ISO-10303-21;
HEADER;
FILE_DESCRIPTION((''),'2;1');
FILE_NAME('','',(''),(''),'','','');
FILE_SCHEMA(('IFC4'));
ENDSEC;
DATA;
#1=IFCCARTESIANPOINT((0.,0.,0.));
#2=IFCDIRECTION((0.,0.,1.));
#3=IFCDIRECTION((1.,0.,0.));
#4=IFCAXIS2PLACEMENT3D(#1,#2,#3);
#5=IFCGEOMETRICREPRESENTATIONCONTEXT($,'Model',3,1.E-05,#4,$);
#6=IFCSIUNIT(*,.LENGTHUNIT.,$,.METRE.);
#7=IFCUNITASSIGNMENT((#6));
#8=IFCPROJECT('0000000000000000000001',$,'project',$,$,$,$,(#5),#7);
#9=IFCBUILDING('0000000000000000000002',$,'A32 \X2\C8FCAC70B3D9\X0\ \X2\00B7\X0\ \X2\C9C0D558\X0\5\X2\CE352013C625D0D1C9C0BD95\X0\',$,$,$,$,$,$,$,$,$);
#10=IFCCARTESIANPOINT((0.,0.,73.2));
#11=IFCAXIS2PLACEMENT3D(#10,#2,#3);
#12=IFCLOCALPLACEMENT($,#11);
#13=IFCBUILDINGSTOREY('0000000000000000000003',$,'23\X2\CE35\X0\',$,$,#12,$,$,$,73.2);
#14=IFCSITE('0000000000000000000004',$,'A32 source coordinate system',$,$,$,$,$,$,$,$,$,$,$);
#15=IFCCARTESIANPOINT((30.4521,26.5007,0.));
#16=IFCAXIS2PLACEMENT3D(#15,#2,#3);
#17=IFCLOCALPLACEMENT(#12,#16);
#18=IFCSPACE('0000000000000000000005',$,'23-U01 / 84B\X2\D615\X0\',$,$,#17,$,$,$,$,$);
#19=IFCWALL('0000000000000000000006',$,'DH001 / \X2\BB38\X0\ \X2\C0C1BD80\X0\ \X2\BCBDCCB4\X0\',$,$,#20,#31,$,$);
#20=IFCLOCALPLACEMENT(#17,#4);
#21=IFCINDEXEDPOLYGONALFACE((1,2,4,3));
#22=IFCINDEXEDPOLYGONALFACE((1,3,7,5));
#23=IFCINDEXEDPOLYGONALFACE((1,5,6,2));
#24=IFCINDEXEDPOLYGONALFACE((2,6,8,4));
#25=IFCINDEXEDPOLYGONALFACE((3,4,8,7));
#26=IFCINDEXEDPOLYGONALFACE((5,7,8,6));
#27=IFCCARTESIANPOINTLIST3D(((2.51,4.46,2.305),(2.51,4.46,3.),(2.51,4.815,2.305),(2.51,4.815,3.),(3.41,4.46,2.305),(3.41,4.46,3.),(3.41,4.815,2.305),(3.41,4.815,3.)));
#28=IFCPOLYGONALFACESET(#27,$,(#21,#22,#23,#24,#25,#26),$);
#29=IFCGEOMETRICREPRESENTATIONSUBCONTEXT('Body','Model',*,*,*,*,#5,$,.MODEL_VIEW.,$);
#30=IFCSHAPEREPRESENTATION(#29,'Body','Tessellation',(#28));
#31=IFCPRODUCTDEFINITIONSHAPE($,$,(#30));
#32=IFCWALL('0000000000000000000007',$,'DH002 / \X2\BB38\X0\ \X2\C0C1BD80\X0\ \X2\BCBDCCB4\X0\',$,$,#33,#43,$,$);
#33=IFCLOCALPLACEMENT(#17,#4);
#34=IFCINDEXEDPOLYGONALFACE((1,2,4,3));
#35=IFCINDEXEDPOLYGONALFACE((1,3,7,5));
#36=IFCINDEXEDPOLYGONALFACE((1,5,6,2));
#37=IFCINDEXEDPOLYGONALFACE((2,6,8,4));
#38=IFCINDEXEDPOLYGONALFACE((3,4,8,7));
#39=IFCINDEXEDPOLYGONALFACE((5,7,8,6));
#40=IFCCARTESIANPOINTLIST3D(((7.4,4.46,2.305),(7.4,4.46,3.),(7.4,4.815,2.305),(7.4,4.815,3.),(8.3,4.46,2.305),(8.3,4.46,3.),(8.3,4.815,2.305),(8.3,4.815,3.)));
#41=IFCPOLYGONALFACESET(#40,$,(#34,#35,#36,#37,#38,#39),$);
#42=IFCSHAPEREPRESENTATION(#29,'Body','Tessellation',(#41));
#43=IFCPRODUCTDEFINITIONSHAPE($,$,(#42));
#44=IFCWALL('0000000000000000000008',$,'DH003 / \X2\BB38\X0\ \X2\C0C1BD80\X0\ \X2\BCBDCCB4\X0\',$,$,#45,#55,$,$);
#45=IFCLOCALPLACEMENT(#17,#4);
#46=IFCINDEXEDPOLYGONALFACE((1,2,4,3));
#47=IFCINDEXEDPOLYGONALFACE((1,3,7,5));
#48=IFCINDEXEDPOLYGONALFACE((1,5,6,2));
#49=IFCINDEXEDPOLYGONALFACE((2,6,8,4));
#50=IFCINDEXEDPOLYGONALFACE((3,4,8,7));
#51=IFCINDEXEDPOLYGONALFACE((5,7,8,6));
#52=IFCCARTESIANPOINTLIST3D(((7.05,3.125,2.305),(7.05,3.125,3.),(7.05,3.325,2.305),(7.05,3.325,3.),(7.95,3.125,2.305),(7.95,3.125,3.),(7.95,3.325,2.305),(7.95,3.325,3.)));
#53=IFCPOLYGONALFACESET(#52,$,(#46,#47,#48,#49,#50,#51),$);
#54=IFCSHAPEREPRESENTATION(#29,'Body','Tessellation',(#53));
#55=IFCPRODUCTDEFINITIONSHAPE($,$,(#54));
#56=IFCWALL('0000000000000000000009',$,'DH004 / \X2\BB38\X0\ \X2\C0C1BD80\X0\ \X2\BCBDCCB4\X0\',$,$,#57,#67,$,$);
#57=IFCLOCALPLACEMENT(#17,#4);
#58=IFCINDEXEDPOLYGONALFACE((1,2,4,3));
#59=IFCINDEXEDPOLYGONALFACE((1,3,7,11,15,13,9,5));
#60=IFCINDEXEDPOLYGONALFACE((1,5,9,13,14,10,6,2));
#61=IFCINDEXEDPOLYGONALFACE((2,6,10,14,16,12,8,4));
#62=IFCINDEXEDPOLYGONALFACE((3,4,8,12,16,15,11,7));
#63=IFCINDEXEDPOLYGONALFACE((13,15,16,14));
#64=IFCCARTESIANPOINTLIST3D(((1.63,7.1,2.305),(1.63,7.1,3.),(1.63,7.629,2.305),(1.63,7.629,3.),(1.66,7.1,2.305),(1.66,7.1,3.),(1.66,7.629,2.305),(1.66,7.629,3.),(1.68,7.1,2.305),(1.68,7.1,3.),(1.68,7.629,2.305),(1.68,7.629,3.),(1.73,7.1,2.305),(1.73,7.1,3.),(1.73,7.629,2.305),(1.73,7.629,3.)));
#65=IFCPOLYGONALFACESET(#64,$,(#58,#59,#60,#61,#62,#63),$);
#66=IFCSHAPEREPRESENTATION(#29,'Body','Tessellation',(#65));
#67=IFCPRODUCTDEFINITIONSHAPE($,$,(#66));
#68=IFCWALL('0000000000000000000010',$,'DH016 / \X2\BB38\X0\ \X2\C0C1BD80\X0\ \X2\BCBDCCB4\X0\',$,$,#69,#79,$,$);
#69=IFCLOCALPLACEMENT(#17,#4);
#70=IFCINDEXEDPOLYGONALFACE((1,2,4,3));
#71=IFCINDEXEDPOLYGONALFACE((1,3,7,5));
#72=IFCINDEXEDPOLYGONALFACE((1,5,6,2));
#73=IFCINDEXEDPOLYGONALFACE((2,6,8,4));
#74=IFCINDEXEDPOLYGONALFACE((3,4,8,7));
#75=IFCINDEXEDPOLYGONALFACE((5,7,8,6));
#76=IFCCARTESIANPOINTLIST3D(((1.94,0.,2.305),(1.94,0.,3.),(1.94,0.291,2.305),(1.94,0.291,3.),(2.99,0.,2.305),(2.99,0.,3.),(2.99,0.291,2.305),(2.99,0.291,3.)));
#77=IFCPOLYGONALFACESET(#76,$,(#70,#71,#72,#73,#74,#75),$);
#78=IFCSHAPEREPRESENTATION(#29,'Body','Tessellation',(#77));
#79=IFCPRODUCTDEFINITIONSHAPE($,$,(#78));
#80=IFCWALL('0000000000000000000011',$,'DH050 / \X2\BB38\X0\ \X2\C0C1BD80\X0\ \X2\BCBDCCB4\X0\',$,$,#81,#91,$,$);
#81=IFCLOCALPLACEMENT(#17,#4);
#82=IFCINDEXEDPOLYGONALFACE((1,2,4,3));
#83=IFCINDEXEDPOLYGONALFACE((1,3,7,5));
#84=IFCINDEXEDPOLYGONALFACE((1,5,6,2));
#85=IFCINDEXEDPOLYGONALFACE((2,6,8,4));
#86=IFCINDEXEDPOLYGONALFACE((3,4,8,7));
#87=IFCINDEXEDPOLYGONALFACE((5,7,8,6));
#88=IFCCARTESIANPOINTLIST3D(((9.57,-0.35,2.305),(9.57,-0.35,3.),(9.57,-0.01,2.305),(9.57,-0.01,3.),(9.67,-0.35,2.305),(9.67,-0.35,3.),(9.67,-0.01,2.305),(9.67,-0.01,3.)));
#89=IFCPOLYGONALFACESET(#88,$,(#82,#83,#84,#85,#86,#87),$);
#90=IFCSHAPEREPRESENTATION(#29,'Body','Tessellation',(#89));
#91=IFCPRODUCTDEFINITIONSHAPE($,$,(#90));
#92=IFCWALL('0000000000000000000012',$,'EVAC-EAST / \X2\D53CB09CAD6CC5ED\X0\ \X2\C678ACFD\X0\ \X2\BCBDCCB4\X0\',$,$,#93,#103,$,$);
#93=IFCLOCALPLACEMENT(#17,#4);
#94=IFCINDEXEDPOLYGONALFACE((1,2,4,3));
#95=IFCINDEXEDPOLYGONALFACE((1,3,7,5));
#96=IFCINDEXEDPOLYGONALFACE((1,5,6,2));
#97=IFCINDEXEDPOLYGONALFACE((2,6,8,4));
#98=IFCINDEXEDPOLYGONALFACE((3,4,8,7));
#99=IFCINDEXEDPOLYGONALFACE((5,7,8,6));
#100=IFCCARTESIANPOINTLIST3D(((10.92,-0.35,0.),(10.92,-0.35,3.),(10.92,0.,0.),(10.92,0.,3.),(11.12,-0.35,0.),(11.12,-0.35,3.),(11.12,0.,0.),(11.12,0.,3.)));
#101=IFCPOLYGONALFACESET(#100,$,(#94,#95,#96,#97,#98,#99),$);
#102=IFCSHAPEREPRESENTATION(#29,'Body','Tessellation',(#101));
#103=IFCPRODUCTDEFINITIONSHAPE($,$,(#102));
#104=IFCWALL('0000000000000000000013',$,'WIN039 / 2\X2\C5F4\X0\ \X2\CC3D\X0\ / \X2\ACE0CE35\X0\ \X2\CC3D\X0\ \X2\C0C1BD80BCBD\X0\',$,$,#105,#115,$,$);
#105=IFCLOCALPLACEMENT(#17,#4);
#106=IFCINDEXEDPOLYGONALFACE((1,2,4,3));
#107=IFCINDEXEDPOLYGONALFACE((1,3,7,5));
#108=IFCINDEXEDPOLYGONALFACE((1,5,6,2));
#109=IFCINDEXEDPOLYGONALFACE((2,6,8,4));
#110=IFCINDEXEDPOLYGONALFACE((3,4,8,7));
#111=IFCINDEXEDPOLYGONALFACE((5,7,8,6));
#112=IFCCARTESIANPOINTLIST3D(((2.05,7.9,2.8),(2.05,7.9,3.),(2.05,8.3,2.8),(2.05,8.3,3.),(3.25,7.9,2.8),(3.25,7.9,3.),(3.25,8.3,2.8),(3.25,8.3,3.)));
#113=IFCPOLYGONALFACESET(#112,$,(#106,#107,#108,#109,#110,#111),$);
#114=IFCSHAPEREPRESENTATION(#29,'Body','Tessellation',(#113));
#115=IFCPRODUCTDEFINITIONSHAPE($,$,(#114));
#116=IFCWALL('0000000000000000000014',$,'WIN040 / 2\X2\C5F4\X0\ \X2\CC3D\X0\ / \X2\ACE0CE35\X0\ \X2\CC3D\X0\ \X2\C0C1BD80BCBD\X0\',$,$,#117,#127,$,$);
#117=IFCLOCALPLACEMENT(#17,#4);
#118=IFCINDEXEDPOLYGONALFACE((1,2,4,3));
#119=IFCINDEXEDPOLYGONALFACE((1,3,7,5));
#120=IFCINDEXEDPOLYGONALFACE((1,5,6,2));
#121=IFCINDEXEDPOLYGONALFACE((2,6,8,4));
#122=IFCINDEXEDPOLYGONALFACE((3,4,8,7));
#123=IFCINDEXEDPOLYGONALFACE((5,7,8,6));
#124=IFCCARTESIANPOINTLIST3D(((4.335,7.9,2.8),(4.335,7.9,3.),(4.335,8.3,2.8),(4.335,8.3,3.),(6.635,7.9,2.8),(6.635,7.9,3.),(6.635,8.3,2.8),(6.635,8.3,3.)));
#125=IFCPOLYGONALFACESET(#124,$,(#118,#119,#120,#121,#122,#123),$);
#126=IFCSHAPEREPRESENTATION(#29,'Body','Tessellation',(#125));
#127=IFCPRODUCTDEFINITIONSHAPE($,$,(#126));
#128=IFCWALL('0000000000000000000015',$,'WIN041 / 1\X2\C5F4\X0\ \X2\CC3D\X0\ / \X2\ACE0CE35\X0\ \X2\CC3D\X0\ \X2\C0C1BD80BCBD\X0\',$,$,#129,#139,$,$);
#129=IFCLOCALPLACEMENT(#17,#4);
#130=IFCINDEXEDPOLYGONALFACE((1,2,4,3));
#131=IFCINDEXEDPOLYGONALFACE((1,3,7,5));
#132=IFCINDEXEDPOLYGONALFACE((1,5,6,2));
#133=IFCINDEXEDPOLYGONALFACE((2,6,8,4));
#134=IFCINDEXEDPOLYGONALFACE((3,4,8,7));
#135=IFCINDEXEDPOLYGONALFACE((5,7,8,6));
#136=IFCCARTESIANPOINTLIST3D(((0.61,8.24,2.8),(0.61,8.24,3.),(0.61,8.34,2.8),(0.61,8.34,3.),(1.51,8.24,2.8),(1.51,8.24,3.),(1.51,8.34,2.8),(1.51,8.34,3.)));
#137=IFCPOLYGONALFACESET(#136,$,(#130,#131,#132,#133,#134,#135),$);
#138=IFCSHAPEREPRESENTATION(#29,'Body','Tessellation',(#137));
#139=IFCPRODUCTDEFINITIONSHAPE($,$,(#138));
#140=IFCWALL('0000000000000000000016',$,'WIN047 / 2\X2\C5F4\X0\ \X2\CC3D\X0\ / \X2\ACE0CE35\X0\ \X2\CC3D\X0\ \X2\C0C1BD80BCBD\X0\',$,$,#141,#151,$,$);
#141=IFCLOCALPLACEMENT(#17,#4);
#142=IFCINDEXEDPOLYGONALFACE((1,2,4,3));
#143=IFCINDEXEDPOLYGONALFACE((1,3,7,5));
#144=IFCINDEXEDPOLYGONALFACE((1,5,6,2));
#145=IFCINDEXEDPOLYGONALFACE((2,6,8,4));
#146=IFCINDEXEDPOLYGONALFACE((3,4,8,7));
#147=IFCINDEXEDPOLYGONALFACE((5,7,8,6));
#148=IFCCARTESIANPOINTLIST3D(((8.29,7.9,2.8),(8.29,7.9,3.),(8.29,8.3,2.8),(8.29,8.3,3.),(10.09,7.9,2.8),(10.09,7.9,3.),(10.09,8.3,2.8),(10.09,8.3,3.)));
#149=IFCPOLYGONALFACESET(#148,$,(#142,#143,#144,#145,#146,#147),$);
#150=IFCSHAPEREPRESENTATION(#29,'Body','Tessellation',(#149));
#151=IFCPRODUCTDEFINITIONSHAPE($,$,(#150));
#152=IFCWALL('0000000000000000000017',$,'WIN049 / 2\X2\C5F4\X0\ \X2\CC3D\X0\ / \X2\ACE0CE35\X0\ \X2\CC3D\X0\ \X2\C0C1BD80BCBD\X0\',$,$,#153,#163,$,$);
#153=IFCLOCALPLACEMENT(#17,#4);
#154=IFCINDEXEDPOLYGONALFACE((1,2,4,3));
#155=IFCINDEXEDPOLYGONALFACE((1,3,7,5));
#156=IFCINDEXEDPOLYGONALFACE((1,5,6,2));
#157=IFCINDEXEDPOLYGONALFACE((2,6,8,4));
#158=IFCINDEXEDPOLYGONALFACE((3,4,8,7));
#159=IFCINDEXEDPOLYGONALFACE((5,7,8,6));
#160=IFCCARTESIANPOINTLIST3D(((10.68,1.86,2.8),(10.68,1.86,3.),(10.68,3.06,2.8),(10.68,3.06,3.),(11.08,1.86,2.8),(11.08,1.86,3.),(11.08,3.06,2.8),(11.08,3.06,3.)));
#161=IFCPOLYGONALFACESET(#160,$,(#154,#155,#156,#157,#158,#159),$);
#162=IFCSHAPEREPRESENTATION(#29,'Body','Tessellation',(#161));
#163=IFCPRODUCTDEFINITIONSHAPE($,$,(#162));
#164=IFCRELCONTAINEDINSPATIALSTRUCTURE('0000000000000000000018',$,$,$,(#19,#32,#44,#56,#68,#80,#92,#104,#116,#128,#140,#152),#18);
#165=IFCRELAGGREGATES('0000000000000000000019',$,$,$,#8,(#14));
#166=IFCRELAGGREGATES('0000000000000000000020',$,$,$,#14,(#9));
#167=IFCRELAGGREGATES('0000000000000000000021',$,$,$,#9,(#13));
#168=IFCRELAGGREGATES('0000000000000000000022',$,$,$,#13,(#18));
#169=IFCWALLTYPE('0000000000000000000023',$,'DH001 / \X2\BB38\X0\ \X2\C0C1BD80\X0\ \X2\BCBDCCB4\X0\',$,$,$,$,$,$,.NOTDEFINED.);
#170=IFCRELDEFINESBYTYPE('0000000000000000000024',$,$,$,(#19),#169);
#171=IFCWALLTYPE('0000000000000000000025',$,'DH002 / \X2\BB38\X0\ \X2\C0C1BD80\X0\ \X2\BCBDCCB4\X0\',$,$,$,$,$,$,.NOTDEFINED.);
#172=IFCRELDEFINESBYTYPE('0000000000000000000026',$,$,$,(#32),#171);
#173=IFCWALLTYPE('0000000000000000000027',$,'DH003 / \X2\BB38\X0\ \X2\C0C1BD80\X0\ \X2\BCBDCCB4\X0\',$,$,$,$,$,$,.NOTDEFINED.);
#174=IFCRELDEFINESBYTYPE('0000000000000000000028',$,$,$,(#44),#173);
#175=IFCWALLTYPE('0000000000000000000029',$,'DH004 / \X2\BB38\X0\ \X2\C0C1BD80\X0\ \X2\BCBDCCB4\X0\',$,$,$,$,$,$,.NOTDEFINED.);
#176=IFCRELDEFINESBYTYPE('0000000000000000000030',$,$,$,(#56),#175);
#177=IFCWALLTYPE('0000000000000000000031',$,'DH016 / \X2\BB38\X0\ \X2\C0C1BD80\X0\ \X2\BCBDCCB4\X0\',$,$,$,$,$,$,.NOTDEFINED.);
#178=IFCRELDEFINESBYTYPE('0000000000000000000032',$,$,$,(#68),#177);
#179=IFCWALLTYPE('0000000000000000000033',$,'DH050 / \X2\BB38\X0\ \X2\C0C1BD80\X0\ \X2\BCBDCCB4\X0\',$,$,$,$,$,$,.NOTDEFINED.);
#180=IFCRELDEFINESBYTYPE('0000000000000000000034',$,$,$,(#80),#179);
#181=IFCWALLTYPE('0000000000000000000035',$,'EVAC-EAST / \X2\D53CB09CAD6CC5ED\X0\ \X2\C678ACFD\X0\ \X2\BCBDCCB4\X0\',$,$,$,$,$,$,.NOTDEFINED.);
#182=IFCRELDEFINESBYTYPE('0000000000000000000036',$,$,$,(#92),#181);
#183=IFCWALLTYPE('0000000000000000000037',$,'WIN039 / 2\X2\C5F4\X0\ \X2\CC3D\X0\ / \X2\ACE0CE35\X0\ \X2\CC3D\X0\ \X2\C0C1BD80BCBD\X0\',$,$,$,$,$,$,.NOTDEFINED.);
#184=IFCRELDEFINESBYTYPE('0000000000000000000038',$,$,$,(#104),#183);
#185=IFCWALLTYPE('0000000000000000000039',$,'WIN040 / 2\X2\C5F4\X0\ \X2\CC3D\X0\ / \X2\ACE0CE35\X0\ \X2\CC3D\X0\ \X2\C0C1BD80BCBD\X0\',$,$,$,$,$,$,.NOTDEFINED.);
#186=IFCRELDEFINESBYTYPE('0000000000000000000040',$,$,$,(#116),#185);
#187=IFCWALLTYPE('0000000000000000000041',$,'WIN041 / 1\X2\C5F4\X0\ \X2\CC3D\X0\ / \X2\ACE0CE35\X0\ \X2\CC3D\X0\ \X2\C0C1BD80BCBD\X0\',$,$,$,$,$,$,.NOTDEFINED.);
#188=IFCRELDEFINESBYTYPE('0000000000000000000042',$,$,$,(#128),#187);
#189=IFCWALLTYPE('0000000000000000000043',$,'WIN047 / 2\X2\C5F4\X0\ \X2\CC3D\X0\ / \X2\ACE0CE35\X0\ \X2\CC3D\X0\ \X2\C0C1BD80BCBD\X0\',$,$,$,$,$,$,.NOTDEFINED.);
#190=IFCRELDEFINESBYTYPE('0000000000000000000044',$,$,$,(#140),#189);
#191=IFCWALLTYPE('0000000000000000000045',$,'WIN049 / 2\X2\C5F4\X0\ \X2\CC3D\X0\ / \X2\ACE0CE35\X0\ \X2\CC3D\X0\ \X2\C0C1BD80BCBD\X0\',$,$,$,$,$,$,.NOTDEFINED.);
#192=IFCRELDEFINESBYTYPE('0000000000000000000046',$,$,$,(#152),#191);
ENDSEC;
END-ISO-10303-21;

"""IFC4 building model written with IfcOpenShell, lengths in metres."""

from ifc_helpers import new_model, si_unit, frame, origin, origin_with_axes, place, context, subcontext, project, spatial, polyline, outline, extrude, source, transform, mapped, type_object, type_shapes, element, save


model = new_model("IFC4")

# Units and contexts
model_context = context("Model", 3, precision=1e-05, world=origin_with_axes())
body_context = subcontext(model_context, "Body", "Model", "MODEL_VIEW")
ifc_project = project(units=[si_unit("LENGTHUNIT", "METRE")], contexts=[model_context])

# Site, building, storey, space
site = spatial("IfcSite", under=ifc_project, Name="A32 source coordinate system")
building = spatial("IfcBuilding", under=site, Name="A32 주거동 · 지하5층–옥탑지붕")
storey_placement = place(None, frame((0.0, 0.0, 73.2), z_axis=(0.0, 0.0, 1.0), x_axis=(1.0, 0.0, 0.0)))
storey = spatial("IfcBuildingStorey", under=building, at=storey_placement, Name="23층", Elevation=73.2)
space_placement = place(storey_placement, frame((30.4521, 26.5007, 0.0), z_axis=(0.0, 0.0, 1.0), x_axis=(1.0, 0.0, 0.0)))
space = spatial("IfcSpace", under=storey, at=space_placement, Name="23-U01 / 84B형")

# Walls
wall_type_1 = type_object("IfcWallType", Name="DH001 / 문 상부 벽체", PredefinedType="NOTDEFINED")
shared_shape_1 = source(origin(), body_context, "Body", "SweptSolid", [
    extrude(outline(polyline([(3.41, 4.815), (3.41, 4.46), (2.51, 4.46), (2.51, 4.815), (3.41, 4.815)])), frame((0.0, 0.0, 2.305)), (0.0, 0.0, 1.0), 0.695),
])
type_shapes(wall_type_1, [shared_shape_1])
wall_1_placement = place(space_placement, origin_with_axes())
element("IfcWall", 1, at=wall_1_placement, inside=space, type_object=wall_type_1, Name="DH001 / 문 상부 벽체", context=body_context, shape_type="MappedRepresentation", body=[
    mapped(shared_shape_1, transform((0.0, 0.0, 0.0), scale=1.0)),
])
wall_type_2 = type_object("IfcWallType", Name="DH002 / 문 상부 벽체", PredefinedType="NOTDEFINED")
shared_shape_2 = source(origin(), body_context, "Body", "SweptSolid", [
    extrude(outline(polyline([(8.3, 4.815), (8.3, 4.46), (7.4, 4.46), (7.4, 4.815), (8.3, 4.815)])), frame((0.0, 0.0, 2.305)), (0.0, 0.0, 1.0), 0.695),
])
type_shapes(wall_type_2, [shared_shape_2])
wall_2_placement = place(space_placement, origin_with_axes())
element("IfcWall", 2, at=wall_2_placement, inside=space, type_object=wall_type_2, Name="DH002 / 문 상부 벽체", context=body_context, shape_type="MappedRepresentation", body=[
    mapped(shared_shape_2, transform((0.0, 0.0, 0.0), scale=1.0)),
])
wall_type_3 = type_object("IfcWallType", Name="DH003 / 문 상부 벽체", PredefinedType="NOTDEFINED")
shared_shape_3 = source(origin(), body_context, "Body", "SweptSolid", [
    extrude(outline(polyline([(7.95, 3.325), (7.95, 3.125), (7.05, 3.125), (7.05, 3.325), (7.95, 3.325)])), frame((0.0, 0.0, 2.305)), (0.0, 0.0, 1.0), 0.695),
])
type_shapes(wall_type_3, [shared_shape_3])
wall_3_placement = place(space_placement, origin_with_axes())
element("IfcWall", 3, at=wall_3_placement, inside=space, type_object=wall_type_3, Name="DH003 / 문 상부 벽체", context=body_context, shape_type="MappedRepresentation", body=[
    mapped(shared_shape_3, transform((0.0, 0.0, 0.0), scale=1.0)),
])
wall_type_4 = type_object("IfcWallType", Name="DH004 / 문 상부 벽체", PredefinedType="NOTDEFINED")
shared_shape_4 = source(origin(), body_context, "Body", "SweptSolid", [
    extrude(outline(polyline([(1.66, 7.1), (1.63, 7.1), (1.63, 7.629), (1.66, 7.629), (1.68, 7.629), (1.73, 7.629), (1.73, 7.1), (1.68, 7.1), (1.66, 7.1)])), frame((0.0, 0.0, 2.305)), (0.0, 0.0, 1.0), 0.695),
])
type_shapes(wall_type_4, [shared_shape_4])
wall_4_placement = place(space_placement, origin_with_axes())
element("IfcWall", 4, at=wall_4_placement, inside=space, type_object=wall_type_4, Name="DH004 / 문 상부 벽체", context=body_context, shape_type="MappedRepresentation", body=[
    mapped(shared_shape_4, transform((0.0, 0.0, 0.0), scale=1.0)),
])
wall_type_5 = type_object("IfcWallType", Name="DH016 / 문 상부 벽체", PredefinedType="NOTDEFINED")
shared_shape_5 = source(origin(), body_context, "Body", "SweptSolid", [
    extrude(outline(polyline([(2.99, 0.291), (2.99, 0.0), (1.94, 0.0), (1.94, 0.291), (2.99, 0.291)])), frame((0.0, 0.0, 2.305)), (0.0, 0.0, 1.0), 0.695),
])
type_shapes(wall_type_5, [shared_shape_5])
wall_5_placement = place(space_placement, origin_with_axes())
element("IfcWall", 5, at=wall_5_placement, inside=space, type_object=wall_type_5, Name="DH016 / 문 상부 벽체", context=body_context, shape_type="MappedRepresentation", body=[
    mapped(shared_shape_5, transform((0.0, 0.0, 0.0), scale=1.0)),
])
wall_type_6 = type_object("IfcWallType", Name="DH050 / 문 상부 벽체", PredefinedType="NOTDEFINED")
shared_shape_6 = source(origin(), body_context, "Body", "SweptSolid", [
    extrude(outline(polyline([(9.67, -0.01), (9.67, -0.35), (9.57, -0.35), (9.57, -0.01), (9.67, -0.01)])), frame((0.0, 0.0, 2.305)), (0.0, 0.0, 1.0), 0.695),
])
type_shapes(wall_type_6, [shared_shape_6])
wall_6_placement = place(space_placement, origin_with_axes())
element("IfcWall", 6, at=wall_6_placement, inside=space, type_object=wall_type_6, Name="DH050 / 문 상부 벽체", context=body_context, shape_type="MappedRepresentation", body=[
    mapped(shared_shape_6, transform((0.0, 0.0, 0.0), scale=1.0)),
])
wall_type_7 = type_object("IfcWallType", Name="EVAC-EAST / 피난구역 외곽 벽체", PredefinedType="NOTDEFINED")
shared_shape_7 = source(origin(), body_context, "Body", "SweptSolid", [
    extrude(outline(polyline([(10.92, 0.0), (11.12, 0.0), (11.12, -0.35), (10.92, -0.35), (10.92, 0.0)])), origin(), (0.0, 0.0, 1.0), 3.0),
])
type_shapes(wall_type_7, [shared_shape_7])
wall_7_placement = place(space_placement, origin_with_axes())
element("IfcWall", 7, at=wall_7_placement, inside=space, type_object=wall_type_7, Name="EVAC-EAST / 피난구역 외곽 벽체", context=body_context, shape_type="MappedRepresentation", body=[
    mapped(shared_shape_7, transform((0.0, 0.0, 0.0), scale=1.0)),
])
wall_type_8 = type_object("IfcWallType", Name="WIN039 / 2열 창 / 고층 창 상부벽", PredefinedType="NOTDEFINED")
shared_shape_8 = source(origin(), body_context, "Body", "SweptSolid", [
    extrude(outline(polyline([(3.25, 7.9), (3.25, 8.3), (2.05, 8.3), (2.05, 7.9), (3.25, 7.9)])), frame((0.0, 0.0, 2.8)), (0.0, 0.0, 1.0), 0.2),
])
type_shapes(wall_type_8, [shared_shape_8])
wall_8_placement = place(space_placement, origin_with_axes())
element("IfcWall", 8, at=wall_8_placement, inside=space, type_object=wall_type_8, Name="WIN039 / 2열 창 / 고층 창 상부벽", context=body_context, shape_type="MappedRepresentation", body=[
    mapped(shared_shape_8, transform((0.0, 0.0, 0.0), scale=1.0)),
])
wall_type_9 = type_object("IfcWallType", Name="WIN040 / 2열 창 / 고층 창 상부벽", PredefinedType="NOTDEFINED")
shared_shape_9 = source(origin(), body_context, "Body", "SweptSolid", [
    extrude(outline(polyline([(6.635, 7.9), (6.635, 8.3), (4.335, 8.3), (4.335, 7.9), (6.635, 7.9)])), frame((0.0, 0.0, 2.8)), (0.0, 0.0, 1.0), 0.2),
])
type_shapes(wall_type_9, [shared_shape_9])
wall_9_placement = place(space_placement, origin_with_axes())
element("IfcWall", 9, at=wall_9_placement, inside=space, type_object=wall_type_9, Name="WIN040 / 2열 창 / 고층 창 상부벽", context=body_context, shape_type="MappedRepresentation", body=[
    mapped(shared_shape_9, transform((0.0, 0.0, 0.0), scale=1.0)),
])
wall_type_10 = type_object("IfcWallType", Name="WIN041 / 1열 창 / 고층 창 상부벽", PredefinedType="NOTDEFINED")
shared_shape_10 = source(origin(), body_context, "Body", "SweptSolid", [
    extrude(outline(polyline([(1.51, 8.24), (1.51, 8.34), (0.61, 8.34), (0.61, 8.24), (1.51, 8.24)])), frame((0.0, 0.0, 2.8)), (0.0, 0.0, 1.0), 0.2),
])
type_shapes(wall_type_10, [shared_shape_10])
wall_10_placement = place(space_placement, origin_with_axes())
element("IfcWall", 10, at=wall_10_placement, inside=space, type_object=wall_type_10, Name="WIN041 / 1열 창 / 고층 창 상부벽", context=body_context, shape_type="MappedRepresentation", body=[
    mapped(shared_shape_10, transform((0.0, 0.0, 0.0), scale=1.0)),
])
wall_type_11 = type_object("IfcWallType", Name="WIN047 / 2열 창 / 고층 창 상부벽", PredefinedType="NOTDEFINED")
shared_shape_11 = source(origin(), body_context, "Body", "SweptSolid", [
    extrude(outline(polyline([(10.09, 7.9), (10.09, 8.3), (8.29, 8.3), (8.29, 7.9), (10.09, 7.9)])), frame((0.0, 0.0, 2.8)), (0.0, 0.0, 1.0), 0.2),
])
type_shapes(wall_type_11, [shared_shape_11])
wall_11_placement = place(space_placement, origin_with_axes())
element("IfcWall", 11, at=wall_11_placement, inside=space, type_object=wall_type_11, Name="WIN047 / 2열 창 / 고층 창 상부벽", context=body_context, shape_type="MappedRepresentation", body=[
    mapped(shared_shape_11, transform((0.0, 0.0, 0.0), scale=1.0)),
])
wall_type_12 = type_object("IfcWallType", Name="WIN049 / 2열 창 / 고층 창 상부벽", PredefinedType="NOTDEFINED")
shared_shape_12 = source(origin(), body_context, "Body", "SweptSolid", [
    extrude(outline(polyline([(11.08, 1.86), (11.08, 3.06), (10.68, 3.06), (10.68, 1.86), (11.08, 1.86)])), frame((0.0, 0.0, 2.8)), (0.0, 0.0, 1.0), 0.2),
])
type_shapes(wall_type_12, [shared_shape_12])
wall_12_placement = place(space_placement, origin_with_axes())
element("IfcWall", 12, at=wall_12_placement, inside=space, type_object=wall_type_12, Name="WIN049 / 2열 창 / 고층 창 상부벽", context=body_context, shape_type="MappedRepresentation", body=[
    mapped(shared_shape_12, transform((0.0, 0.0, 0.0), scale=1.0)),
])

save(model, "model.ifc")
